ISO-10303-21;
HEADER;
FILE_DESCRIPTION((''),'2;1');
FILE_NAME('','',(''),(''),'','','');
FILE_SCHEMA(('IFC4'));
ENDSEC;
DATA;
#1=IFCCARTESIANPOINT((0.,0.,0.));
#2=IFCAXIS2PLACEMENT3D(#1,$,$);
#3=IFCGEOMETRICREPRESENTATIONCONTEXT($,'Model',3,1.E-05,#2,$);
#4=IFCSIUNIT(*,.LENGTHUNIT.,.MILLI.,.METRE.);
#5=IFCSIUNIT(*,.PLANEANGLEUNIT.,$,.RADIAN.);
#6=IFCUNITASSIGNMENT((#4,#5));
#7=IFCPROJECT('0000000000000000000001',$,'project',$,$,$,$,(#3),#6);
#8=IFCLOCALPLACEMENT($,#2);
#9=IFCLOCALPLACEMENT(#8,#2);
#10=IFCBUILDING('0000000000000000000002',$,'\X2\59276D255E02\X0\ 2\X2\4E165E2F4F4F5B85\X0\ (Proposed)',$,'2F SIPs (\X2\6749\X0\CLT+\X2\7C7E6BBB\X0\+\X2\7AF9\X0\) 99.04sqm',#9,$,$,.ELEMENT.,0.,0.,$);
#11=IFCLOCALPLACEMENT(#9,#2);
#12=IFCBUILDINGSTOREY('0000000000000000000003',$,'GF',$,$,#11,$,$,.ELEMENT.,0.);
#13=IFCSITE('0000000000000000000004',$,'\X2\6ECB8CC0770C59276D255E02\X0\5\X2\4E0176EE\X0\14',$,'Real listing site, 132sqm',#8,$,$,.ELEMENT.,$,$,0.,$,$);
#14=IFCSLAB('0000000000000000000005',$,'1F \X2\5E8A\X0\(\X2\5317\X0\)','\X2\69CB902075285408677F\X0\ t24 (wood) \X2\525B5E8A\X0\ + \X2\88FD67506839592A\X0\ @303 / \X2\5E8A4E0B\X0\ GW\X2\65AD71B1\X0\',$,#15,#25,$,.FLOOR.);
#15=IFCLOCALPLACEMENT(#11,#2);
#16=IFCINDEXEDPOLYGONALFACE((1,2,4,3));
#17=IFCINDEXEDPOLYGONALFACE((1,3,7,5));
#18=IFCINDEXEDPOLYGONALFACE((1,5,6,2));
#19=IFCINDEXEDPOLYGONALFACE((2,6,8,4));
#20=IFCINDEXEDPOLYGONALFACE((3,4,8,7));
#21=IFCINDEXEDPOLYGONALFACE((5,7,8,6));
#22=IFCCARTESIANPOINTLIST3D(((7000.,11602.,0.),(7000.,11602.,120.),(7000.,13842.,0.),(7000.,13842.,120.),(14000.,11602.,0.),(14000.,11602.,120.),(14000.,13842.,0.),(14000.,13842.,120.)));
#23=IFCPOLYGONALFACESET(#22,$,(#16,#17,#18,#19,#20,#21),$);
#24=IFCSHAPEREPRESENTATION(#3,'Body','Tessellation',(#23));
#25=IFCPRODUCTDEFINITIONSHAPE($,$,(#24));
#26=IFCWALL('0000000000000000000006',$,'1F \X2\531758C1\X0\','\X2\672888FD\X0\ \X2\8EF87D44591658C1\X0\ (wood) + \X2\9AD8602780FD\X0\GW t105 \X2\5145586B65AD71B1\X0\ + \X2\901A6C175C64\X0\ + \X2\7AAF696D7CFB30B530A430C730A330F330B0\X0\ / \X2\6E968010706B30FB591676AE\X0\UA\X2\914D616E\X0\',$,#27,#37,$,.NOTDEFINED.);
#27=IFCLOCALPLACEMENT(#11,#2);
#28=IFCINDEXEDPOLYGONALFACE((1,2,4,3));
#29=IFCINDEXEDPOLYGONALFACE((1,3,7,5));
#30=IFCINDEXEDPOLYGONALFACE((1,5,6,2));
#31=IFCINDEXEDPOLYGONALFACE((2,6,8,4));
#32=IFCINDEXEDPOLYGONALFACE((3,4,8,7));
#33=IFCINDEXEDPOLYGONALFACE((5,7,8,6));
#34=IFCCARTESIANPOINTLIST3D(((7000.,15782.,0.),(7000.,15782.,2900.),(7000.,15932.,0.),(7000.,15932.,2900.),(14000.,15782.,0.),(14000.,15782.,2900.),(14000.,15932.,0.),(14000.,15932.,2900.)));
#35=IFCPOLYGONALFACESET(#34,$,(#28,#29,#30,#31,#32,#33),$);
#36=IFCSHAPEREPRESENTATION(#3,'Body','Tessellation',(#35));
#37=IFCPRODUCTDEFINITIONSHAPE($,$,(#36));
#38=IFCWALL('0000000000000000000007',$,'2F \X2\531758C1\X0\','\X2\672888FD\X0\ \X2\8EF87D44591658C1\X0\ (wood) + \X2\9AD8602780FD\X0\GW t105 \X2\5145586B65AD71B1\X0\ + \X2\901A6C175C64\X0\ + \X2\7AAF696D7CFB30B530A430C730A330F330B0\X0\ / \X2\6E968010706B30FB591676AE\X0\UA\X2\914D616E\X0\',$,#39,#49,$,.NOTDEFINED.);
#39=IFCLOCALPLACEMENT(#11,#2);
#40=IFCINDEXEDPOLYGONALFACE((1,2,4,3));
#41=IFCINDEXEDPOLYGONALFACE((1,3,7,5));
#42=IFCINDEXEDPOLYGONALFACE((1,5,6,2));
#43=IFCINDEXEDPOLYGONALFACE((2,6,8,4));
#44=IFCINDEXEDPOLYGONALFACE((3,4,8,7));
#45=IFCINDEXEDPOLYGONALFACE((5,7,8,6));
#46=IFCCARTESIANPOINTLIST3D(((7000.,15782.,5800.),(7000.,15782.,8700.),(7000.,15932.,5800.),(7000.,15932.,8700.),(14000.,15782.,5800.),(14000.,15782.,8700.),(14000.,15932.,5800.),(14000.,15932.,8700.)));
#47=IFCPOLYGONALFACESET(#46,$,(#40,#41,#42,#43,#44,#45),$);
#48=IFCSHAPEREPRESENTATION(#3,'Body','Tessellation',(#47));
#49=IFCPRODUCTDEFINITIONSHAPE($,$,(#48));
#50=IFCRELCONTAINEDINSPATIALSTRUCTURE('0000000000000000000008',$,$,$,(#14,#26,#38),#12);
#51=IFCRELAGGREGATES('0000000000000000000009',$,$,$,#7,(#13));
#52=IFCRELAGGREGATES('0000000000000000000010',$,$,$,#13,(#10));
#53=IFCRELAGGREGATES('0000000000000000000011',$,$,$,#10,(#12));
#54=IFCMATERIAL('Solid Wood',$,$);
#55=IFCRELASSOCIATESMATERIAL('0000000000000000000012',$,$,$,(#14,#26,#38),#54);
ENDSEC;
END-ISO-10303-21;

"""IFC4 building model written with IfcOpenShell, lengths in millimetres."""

from ifc_helpers import new_model, si_unit, frame, frame_2d, origin, place, context, project, spatial, rectangle, extrude, material, element, save


model = new_model("IFC4")

# Units and contexts
model_context = context("Model", 3, precision=1e-05, world=origin())
ifc_project = project(units=[si_unit("LENGTHUNIT", "METRE", prefix="MILLI"), si_unit("PLANEANGLEUNIT", "RADIAN")], contexts=[model_context])

# Site, building, storey
site_placement = place(None, origin())
site = spatial("IfcSite", under=ifc_project, at=site_placement, Name="滋賀県大津市5丁目14", ObjectType="Real listing site, 132sqm", CompositionType="ELEMENT", RefElevation=0.0)
building_placement = place(site_placement, origin())
building = spatial("IfcBuilding", under=site, at=building_placement, Name="大津市 2世帯住宅 (Proposed)", ObjectType="2F SIPs (杉CLT+籾殻+竹) 99.04sqm", CompositionType="ELEMENT", ElevationOfRefHeight=0.0, ElevationOfTerrain=0.0)
storey_placement = place(building_placement, origin())
storey = spatial("IfcBuildingStorey", under=building, at=storey_placement, Name="GF", CompositionType="ELEMENT", Elevation=0.0)

# Slab
ifc_material_1 = material(Name="Solid Wood")
slab_1_placement = place(storey_placement, frame((3500.0, 5801.0, 0.0)))
element("IfcSlab", 1, at=slab_1_placement, inside=storey, material=ifc_material_1, Name="1F 床(北)", Description="構造用合板 t24 (wood) 剛床 + 製材根太 @303 / 床下 GW断熱", PredefinedType="FLOOR", context=model_context, shape_type="SweptSolid", body=[
    extrude(rectangle(XDim=7000.0, YDim=2240.0, at=frame_2d((3500.0, 1120.0))), frame((3500.0, 5801.0, 0.0)), (0.0, 0.0, 1.0), 120.0),
])

# Wall
wall_1_placement = place(storey_placement, frame((3500.0, 7891.0, 0.0)))
element("IfcWall", 2, at=wall_1_placement, inside=storey, material=ifc_material_1, Name="1F 北壁", Description="木製 軸組外壁 (wood) + 高性能GW t105 充填断熱 + 通気層 + 窯業系サイディング / 準耐火・外皮UA配慮", PredefinedType="NOTDEFINED", context=model_context, shape_type="SweptSolid", body=[
    extrude(rectangle(XDim=7000.0, YDim=150.0, at=frame_2d((3500.0, 75.0))), frame((3500.0, 7891.0, 0.0)), (0.0, 0.0, 1.0), 2900.0),
])

# Wall
wall_2_placement = place(storey_placement, frame((3500.0, 7891.0, 2900.0)))
element("IfcWall", 3, at=wall_2_placement, inside=storey, material=ifc_material_1, Name="2F 北壁", Description="木製 軸組外壁 (wood) + 高性能GW t105 充填断熱 + 通気層 + 窯業系サイディング / 準耐火・外皮UA配慮", PredefinedType="NOTDEFINED", context=model_context, shape_type="SweptSolid", body=[
    extrude(rectangle(XDim=7000.0, YDim=150.0, at=frame_2d((3500.0, 75.0))), frame((3500.0, 7891.0, 2900.0)), (0.0, 0.0, 1.0), 2900.0),
])

save(model, "model.ifc")
